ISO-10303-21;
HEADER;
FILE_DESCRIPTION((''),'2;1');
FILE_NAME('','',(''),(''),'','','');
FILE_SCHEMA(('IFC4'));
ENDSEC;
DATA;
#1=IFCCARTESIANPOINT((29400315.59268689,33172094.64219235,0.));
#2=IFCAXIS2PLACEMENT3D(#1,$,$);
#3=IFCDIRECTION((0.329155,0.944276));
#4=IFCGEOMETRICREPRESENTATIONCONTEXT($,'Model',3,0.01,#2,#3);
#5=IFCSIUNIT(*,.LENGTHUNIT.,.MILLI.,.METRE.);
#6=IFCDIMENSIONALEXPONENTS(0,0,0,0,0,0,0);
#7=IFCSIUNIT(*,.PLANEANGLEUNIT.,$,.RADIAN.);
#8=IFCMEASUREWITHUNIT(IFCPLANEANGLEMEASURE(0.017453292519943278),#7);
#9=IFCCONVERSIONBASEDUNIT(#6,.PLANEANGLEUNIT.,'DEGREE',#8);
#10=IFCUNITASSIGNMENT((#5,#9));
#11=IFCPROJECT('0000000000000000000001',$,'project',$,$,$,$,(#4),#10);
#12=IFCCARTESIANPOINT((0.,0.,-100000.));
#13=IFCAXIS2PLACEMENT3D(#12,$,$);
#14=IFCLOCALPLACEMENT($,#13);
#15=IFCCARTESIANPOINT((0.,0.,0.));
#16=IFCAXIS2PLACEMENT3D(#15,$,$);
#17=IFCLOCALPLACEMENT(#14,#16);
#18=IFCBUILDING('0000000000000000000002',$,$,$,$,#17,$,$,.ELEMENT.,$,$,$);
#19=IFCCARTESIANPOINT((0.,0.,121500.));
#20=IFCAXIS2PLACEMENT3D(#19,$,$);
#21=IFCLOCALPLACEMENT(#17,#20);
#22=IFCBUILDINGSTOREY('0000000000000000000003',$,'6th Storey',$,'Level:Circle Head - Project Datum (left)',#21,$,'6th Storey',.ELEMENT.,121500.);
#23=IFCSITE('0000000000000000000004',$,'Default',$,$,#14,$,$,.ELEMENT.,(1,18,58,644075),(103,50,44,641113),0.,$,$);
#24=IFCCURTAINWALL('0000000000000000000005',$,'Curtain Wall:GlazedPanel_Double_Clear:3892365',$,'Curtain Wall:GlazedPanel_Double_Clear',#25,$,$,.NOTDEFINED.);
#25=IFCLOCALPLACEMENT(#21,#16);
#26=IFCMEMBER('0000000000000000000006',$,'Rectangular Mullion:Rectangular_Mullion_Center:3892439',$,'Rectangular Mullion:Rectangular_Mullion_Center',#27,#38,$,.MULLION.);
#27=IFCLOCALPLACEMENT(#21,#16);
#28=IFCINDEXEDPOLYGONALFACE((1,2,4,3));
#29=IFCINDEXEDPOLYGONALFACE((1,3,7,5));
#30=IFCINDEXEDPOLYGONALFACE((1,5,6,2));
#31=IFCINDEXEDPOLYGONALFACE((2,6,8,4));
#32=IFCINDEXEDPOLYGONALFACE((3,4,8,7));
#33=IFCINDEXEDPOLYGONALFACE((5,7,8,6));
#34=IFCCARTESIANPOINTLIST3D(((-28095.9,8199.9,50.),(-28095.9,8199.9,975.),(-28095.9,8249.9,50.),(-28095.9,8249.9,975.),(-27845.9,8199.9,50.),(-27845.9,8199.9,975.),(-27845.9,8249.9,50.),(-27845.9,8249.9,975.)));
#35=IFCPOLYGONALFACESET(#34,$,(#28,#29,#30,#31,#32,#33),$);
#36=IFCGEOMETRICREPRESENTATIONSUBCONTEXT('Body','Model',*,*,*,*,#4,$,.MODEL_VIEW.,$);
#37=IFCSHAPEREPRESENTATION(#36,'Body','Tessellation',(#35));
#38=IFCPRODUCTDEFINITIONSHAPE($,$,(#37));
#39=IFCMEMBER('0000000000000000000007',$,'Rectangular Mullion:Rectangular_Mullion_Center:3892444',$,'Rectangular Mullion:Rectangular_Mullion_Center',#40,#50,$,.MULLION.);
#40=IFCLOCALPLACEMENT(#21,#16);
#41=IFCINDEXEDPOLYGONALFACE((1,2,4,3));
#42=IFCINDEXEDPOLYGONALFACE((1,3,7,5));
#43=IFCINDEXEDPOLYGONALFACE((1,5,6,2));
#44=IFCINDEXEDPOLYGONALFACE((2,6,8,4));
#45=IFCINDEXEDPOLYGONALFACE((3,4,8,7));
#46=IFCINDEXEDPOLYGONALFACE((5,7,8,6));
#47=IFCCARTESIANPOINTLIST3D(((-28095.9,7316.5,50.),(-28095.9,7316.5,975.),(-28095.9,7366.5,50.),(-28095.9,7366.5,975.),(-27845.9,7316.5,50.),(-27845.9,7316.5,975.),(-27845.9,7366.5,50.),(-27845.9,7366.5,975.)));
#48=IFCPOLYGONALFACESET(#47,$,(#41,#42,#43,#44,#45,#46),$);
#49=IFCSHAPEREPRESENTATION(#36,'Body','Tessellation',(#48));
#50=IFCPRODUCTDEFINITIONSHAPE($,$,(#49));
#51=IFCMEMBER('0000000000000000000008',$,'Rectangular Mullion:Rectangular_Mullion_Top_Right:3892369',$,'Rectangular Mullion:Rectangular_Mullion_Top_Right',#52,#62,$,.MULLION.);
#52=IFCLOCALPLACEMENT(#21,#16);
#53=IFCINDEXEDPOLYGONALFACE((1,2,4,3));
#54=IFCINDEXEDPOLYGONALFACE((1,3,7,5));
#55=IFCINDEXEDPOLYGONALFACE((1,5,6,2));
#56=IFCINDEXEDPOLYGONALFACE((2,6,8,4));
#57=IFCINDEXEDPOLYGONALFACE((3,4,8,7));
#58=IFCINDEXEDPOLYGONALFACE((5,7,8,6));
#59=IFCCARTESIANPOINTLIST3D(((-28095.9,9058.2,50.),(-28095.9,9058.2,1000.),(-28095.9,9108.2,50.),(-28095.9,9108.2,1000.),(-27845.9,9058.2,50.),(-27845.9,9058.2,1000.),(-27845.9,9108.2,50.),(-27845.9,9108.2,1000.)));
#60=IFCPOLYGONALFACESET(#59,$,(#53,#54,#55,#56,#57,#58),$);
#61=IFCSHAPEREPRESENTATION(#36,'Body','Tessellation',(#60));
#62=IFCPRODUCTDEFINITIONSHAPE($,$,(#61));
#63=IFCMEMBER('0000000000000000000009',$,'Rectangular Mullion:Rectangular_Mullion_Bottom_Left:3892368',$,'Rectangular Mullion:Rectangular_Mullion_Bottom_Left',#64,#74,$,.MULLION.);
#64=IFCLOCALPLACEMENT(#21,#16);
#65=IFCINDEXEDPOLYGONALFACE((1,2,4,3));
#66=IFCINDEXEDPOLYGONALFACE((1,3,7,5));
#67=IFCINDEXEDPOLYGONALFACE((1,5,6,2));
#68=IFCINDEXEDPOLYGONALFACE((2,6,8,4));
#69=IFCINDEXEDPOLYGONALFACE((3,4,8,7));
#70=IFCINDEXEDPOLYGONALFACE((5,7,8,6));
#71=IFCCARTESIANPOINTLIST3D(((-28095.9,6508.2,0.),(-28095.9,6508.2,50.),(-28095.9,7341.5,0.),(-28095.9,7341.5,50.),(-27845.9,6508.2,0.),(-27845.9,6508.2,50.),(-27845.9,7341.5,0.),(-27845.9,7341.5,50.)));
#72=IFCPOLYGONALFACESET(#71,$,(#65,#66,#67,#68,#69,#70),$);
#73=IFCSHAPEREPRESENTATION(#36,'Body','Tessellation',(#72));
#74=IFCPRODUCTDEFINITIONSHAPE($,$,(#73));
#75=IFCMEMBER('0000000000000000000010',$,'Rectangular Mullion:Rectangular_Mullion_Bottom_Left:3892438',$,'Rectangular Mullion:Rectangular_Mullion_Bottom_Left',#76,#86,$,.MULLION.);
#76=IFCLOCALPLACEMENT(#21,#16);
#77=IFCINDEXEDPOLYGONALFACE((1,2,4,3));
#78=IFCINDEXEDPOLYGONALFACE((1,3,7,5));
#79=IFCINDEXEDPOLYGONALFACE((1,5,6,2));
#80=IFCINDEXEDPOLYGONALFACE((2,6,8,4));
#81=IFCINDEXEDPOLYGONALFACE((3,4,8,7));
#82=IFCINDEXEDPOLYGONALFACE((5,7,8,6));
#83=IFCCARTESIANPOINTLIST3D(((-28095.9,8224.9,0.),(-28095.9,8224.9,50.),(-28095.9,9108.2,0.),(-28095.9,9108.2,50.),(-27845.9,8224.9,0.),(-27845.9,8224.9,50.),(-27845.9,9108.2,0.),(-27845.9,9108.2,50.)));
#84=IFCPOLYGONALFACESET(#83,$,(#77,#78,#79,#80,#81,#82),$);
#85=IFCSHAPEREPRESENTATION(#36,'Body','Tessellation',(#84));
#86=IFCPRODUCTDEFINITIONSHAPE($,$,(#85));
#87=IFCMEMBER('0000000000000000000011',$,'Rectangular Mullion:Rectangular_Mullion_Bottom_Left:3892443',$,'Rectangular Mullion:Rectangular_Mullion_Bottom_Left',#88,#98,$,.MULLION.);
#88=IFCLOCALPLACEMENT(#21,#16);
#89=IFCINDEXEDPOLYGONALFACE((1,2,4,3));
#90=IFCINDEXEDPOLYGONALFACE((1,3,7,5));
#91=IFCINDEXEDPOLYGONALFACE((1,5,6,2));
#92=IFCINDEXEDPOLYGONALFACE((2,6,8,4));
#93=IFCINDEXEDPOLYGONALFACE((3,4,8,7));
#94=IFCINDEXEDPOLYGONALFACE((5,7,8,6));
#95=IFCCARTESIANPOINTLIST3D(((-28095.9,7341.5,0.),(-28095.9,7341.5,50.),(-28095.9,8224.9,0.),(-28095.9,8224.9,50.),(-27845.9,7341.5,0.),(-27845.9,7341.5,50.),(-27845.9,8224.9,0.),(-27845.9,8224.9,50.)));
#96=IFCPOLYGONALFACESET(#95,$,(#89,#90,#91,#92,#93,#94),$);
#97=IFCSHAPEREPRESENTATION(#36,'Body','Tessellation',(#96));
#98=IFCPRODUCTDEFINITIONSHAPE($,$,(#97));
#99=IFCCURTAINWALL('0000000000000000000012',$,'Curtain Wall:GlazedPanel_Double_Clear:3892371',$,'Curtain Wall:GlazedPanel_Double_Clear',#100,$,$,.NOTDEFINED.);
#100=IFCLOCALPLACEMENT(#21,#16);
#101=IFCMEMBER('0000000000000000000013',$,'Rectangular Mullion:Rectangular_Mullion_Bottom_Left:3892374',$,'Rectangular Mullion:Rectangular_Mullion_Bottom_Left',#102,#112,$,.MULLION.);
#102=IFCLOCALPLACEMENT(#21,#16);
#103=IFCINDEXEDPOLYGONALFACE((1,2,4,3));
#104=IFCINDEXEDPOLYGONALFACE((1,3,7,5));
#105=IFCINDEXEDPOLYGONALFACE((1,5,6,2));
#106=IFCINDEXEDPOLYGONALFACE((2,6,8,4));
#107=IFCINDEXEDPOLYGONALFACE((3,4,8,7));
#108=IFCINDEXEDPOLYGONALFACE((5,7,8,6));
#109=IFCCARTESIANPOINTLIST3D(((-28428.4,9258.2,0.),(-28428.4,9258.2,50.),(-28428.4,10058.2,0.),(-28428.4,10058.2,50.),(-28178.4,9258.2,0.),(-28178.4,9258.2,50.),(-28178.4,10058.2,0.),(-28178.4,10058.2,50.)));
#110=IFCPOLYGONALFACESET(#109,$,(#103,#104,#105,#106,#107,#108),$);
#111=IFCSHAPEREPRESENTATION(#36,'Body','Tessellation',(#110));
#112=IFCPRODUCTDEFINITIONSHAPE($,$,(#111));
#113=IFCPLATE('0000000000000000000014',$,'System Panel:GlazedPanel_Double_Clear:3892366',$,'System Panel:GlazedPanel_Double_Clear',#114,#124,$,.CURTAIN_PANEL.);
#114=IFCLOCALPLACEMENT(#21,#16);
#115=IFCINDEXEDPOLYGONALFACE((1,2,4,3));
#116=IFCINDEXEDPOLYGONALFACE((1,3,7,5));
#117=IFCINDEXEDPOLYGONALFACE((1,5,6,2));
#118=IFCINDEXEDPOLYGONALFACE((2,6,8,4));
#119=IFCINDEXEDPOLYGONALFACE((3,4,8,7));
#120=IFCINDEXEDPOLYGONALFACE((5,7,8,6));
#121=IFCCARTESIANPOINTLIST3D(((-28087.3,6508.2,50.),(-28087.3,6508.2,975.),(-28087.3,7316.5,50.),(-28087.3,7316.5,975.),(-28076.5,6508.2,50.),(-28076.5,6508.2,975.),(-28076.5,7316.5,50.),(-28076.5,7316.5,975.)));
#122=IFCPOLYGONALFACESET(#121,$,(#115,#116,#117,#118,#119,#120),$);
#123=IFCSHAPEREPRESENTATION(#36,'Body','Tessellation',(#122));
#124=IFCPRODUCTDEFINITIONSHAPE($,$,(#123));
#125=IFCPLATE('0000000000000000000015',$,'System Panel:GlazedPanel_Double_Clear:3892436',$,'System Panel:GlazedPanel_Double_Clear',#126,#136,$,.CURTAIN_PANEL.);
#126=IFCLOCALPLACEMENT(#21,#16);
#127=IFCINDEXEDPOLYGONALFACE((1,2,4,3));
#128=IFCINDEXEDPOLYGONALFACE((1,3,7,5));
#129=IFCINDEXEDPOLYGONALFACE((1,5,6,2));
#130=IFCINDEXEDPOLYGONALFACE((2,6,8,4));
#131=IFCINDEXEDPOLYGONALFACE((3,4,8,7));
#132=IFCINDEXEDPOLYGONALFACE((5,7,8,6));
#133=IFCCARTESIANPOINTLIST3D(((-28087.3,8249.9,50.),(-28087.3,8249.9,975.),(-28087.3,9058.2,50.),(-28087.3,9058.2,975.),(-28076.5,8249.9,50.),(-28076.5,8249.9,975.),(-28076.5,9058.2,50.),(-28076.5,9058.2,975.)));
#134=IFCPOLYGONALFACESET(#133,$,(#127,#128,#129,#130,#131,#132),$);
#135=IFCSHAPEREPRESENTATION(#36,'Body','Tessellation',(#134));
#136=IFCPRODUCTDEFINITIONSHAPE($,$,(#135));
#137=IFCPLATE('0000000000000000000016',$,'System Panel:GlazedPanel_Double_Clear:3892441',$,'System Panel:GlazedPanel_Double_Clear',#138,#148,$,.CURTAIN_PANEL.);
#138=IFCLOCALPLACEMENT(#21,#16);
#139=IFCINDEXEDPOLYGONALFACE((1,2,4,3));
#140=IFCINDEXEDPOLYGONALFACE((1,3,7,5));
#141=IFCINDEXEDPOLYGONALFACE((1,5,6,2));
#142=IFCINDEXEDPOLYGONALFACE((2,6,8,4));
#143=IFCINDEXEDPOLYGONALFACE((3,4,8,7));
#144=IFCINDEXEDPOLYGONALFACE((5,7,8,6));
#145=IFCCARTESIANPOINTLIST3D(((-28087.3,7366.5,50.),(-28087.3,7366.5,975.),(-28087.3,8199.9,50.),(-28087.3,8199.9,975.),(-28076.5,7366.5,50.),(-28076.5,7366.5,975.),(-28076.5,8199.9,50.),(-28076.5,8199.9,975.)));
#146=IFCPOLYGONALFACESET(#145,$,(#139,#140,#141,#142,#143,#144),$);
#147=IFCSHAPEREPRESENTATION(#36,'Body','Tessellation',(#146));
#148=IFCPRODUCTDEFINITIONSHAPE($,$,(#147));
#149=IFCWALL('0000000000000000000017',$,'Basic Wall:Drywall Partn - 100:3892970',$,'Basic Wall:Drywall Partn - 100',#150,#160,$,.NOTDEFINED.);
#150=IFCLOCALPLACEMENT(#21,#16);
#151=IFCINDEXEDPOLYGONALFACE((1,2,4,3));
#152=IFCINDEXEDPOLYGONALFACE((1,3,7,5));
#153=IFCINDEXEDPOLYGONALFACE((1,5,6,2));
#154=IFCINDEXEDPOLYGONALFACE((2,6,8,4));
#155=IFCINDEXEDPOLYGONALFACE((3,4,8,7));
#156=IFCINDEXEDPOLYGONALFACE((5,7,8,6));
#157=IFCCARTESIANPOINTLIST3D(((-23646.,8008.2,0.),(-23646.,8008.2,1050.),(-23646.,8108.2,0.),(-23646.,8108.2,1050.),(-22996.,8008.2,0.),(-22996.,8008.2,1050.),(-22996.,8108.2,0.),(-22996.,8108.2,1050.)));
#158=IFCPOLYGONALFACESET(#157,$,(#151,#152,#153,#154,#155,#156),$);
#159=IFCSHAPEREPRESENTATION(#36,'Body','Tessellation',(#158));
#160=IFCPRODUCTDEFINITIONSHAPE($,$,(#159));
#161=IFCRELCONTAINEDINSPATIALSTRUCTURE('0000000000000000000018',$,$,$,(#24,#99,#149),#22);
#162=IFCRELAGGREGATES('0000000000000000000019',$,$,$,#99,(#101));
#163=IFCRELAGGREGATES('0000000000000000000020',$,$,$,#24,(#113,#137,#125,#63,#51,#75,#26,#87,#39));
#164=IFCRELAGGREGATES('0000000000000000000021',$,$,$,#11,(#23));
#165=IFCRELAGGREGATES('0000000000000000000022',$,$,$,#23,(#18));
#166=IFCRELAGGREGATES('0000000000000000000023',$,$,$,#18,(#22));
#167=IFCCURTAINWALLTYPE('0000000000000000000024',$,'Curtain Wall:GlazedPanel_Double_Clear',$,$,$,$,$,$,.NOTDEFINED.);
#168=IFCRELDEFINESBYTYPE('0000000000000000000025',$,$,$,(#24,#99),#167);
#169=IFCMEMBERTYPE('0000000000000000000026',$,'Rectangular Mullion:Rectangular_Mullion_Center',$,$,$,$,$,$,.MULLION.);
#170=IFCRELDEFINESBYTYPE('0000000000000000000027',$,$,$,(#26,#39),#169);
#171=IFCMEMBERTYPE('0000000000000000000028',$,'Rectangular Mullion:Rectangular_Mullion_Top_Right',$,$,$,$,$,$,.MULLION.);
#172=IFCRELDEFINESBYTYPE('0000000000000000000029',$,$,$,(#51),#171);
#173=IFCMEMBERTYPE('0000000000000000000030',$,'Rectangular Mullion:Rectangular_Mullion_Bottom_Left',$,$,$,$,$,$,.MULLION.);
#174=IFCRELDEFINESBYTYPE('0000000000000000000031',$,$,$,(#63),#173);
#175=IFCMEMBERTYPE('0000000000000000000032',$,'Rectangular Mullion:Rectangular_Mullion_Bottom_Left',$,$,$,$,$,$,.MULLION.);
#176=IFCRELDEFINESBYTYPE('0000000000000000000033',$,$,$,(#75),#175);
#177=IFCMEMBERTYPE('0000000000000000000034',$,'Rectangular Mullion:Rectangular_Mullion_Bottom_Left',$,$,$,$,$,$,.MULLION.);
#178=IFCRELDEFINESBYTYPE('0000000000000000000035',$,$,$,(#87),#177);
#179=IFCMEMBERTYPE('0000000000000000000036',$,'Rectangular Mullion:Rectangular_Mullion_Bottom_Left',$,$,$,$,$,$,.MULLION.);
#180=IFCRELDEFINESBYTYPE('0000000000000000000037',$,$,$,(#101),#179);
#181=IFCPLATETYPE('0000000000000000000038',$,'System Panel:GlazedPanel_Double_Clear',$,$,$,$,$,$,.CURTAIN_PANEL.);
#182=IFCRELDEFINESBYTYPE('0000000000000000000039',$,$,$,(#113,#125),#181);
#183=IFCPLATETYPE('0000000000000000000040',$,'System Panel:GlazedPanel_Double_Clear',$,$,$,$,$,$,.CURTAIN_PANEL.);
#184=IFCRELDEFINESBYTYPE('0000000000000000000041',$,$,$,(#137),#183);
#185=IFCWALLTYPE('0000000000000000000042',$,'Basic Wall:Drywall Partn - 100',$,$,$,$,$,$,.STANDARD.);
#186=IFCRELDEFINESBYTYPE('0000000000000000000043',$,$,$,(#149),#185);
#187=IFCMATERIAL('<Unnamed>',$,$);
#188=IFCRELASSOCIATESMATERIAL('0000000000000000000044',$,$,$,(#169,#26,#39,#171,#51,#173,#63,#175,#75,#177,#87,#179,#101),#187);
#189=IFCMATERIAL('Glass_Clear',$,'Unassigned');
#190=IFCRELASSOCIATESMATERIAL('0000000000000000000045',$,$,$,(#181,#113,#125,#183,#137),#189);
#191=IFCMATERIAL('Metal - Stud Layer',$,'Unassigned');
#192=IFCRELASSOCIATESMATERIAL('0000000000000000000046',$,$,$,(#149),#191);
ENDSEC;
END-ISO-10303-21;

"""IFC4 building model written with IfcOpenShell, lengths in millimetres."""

from ifc_helpers import new_model, entity, si_unit, converted_unit, direction, frame, origin, place, context, subcontext, project, spatial, indexed_curve, outline, extrude, source, transform, mapped, material, type_object, type_shapes, element, aggregate, save


model = new_model("IFC4")

# Units and contexts
model_context = context("Model", 3, precision=0.01, world=frame((29400315.59268689, 33172094.64219235, 0.0)), true_north=direction((0.329155, 0.944276)))
body_context = subcontext(model_context, "Body", "Model", "MODEL_VIEW")
ifc_project = project(units=[si_unit("LENGTHUNIT", "METRE", prefix="MILLI"), converted_unit("PLANEANGLEUNIT", "DEGREE", entity("IfcPlaneAngleMeasure", 0.017453292519943278), si_unit("PLANEANGLEUNIT", "RADIAN"), dimensions=[0, 0, 0, 0, 0, 0, 0])], contexts=[model_context])

# Site, building, storey
site_placement = place(None, frame((0.0, 0.0, -100000.0)))
site = spatial("IfcSite", under=ifc_project, at=site_placement, Name="Default", CompositionType="ELEMENT", RefLatitude=(1, 18, 58, 644075), RefLongitude=(103, 50, 44, 641113), RefElevation=0.0)
building_placement = place(site_placement, origin())
building = spatial("IfcBuilding", under=site, at=building_placement, CompositionType="ELEMENT")
storey_placement = place(building_placement, frame((0.0, 0.0, 121500.0)))
storey = spatial("IfcBuildingStorey", under=building, at=storey_placement, Name="6th Storey", ObjectType="Level:Circle Head - Project Datum (left)", LongName="6th Storey", CompositionType="ELEMENT", Elevation=121500.0)

# Curtain wall, members
curtain_wall_type = type_object("IfcCurtainWallType", Name="Curtain Wall:GlazedPanel_Double_Clear", PredefinedType="NOTDEFINED")
curtain_wall_1_placement = place(storey_placement, frame((0.0, 0.0, -121500.0)))
curtain_wall_1 = element("IfcCurtainWall", 1, at=curtain_wall_1_placement, inside=storey, type_object=curtain_wall_type, Name="Curtain Wall:GlazedPanel_Double_Clear:3892365", ObjectType="Curtain Wall:GlazedPanel_Double_Clear", PredefinedType="NOTDEFINED")
ifc_material_1 = material(Name="<Unnamed>")
member_type_1 = type_object("IfcMemberType", Name="Rectangular Mullion:Rectangular_Mullion_Center", PredefinedType="MULLION", material=ifc_material_1)
shared_shape_1 = source(origin(), body_context, "Body", "SweptSolid", [
    extrude(outline(indexed_curve([(-25.0, -125.0), (25.0, -125.0), (25.0, 125.0), (-25.0, 125.0), (-25.0, -125.0)], self_intersect=False)), frame((0.0, 0.0, -925.0), z_axis=(0.0, 0.0, 1.0), x_axis=(-1.0, 0.0, 0.0)), (0.0, 0.0, 1.0), 925.0),
])
type_shapes(member_type_1, [shared_shape_1])
member_1_placement = place(curtain_wall_1_placement, frame((-27970.9, 8224.9, 121550.0), z_axis=(0.0, 0.0, -1.0), x_axis=(0.0, 1.0, 0.0)))
member_1 = element("IfcMember", 2, at=member_1_placement, type_object=member_type_1, material=ifc_material_1, Name="Rectangular Mullion:Rectangular_Mullion_Center:3892439", ObjectType="Rectangular Mullion:Rectangular_Mullion_Center", PredefinedType="MULLION", context=body_context, shape_type="MappedRepresentation", body=[
    mapped(shared_shape_1, transform((0.0, 0.0, 0.0), scale=1.0)),
])
member_2_placement = place(curtain_wall_1_placement, frame((-27970.9, 7341.5, 121550.0), z_axis=(0.0, 0.0, -1.0), x_axis=(0.0, 1.0, 0.0)))
member_2 = element("IfcMember", 3, at=member_2_placement, type_object=member_type_1, material=ifc_material_1, Name="Rectangular Mullion:Rectangular_Mullion_Center:3892444", ObjectType="Rectangular Mullion:Rectangular_Mullion_Center", PredefinedType="MULLION", context=body_context, shape_type="MappedRepresentation", body=[
    mapped(shared_shape_1, transform((0.0, 0.0, 0.0), scale=1.0)),
])
member_type_2 = type_object("IfcMemberType", Name="Rectangular Mullion:Rectangular_Mullion_Top_Right", PredefinedType="MULLION", material=ifc_material_1)
shared_shape_2 = source(origin(), body_context, "Body", "SweptSolid", [
    extrude(outline(indexed_curve([(-25.0, -125.0), (25.0, -125.0), (25.0, 125.0), (-25.0, 125.0), (-25.0, -125.0)], self_intersect=False)), frame((-25.0, 0.0, -950.0), z_axis=(0.0, 0.0, 1.0), x_axis=(-1.0, 0.0, 0.0)), (0.0, 0.0, 1.0), 950.0),
])
type_shapes(member_type_2, [shared_shape_2])
member_3_placement = place(curtain_wall_1_placement, frame((-27970.9, 9108.2, 121550.0), z_axis=(0.0, 0.0, -1.0), x_axis=(0.0, 1.0, 0.0)))
member_3 = element("IfcMember", 4, at=member_3_placement, type_object=member_type_2, material=ifc_material_1, Name="Rectangular Mullion:Rectangular_Mullion_Top_Right:3892369", ObjectType="Rectangular Mullion:Rectangular_Mullion_Top_Right", PredefinedType="MULLION", context=body_context, shape_type="MappedRepresentation", body=[
    mapped(shared_shape_2, transform((0.0, 0.0, 0.0), scale=1.0)),
])
member_type_3 = type_object("IfcMemberType", Name="Rectangular Mullion:Rectangular_Mullion_Bottom_Left", PredefinedType="MULLION", material=ifc_material_1)
shared_shape_3 = source(origin(), body_context, "Body", "SweptSolid", [
    extrude(outline(indexed_curve([(-25.0, -125.0), (25.0, -125.0), (25.0, 125.0), (-25.0, 125.0), (-25.0, -125.0)], self_intersect=False)), frame((-25.0, 0.0, -833.3), z_axis=(0.0, 0.0, 1.0), x_axis=(-1.0, 0.0, 0.0)), (0.0, 0.0, 1.0), 833.3),
])
type_shapes(member_type_3, [shared_shape_3])
member_4_placement = place(curtain_wall_1_placement, frame((-27970.9, 6508.2, 121500.0), z_axis=(0.0, -1.0, 0.0), x_axis=(0.0, 0.0, -1.0)))
member_4 = element("IfcMember", 5, at=member_4_placement, type_object=member_type_3, material=ifc_material_1, Name="Rectangular Mullion:Rectangular_Mullion_Bottom_Left:3892368", ObjectType="Rectangular Mullion:Rectangular_Mullion_Bottom_Left", PredefinedType="MULLION", context=body_context, shape_type="MappedRepresentation", body=[
    mapped(shared_shape_3, transform((0.0, 0.0, 0.0), scale=1.0)),
])
member_type_4 = type_object("IfcMemberType", Name="Rectangular Mullion:Rectangular_Mullion_Bottom_Left", PredefinedType="MULLION", material=ifc_material_1)
shared_shape_4 = source(origin(), body_context, "Body", "SweptSolid", [
    extrude(outline(indexed_curve([(-25.0, -125.0), (25.0, -125.0), (25.0, 125.0), (-25.0, 125.0), (-25.0, -125.0)], self_intersect=False)), frame((-25.0, 0.0, -883.3), z_axis=(0.0, 0.0, 1.0), x_axis=(-1.0, 0.0, 0.0)), (0.0, 0.0, 1.0), 883.3),
])
type_shapes(member_type_4, [shared_shape_4])
member_5_placement = place(curtain_wall_1_placement, frame((-27970.9, 8224.9, 121500.0), z_axis=(0.0, -1.0, 0.0), x_axis=(0.0, 0.0, -1.0)))
member_5 = element("IfcMember", 6, at=member_5_placement, type_object=member_type_4, material=ifc_material_1, Name="Rectangular Mullion:Rectangular_Mullion_Bottom_Left:3892438", ObjectType="Rectangular Mullion:Rectangular_Mullion_Bottom_Left", PredefinedType="MULLION", context=body_context, shape_type="MappedRepresentation", body=[
    mapped(shared_shape_4, transform((0.0, 0.0, 0.0), scale=1.0)),
])
member_type_5 = type_object("IfcMemberType", Name="Rectangular Mullion:Rectangular_Mullion_Bottom_Left", PredefinedType="MULLION", material=ifc_material_1)
shared_shape_5 = source(origin(), body_context, "Body", "SweptSolid", [
    extrude(outline(indexed_curve([(-25.0, -125.0), (25.0, -125.0), (25.0, 125.0), (-25.0, 125.0), (-25.0, -125.0)], self_intersect=False)), frame((-25.0, 0.0, -883.3), z_axis=(0.0, 0.0, 1.0), x_axis=(-1.0, 0.0, 0.0)), (0.0, 0.0, 1.0), 883.3),
])
type_shapes(member_type_5, [shared_shape_5])
member_6_placement = place(curtain_wall_1_placement, frame((-27970.9, 7341.5, 121500.0), z_axis=(0.0, -1.0, 0.0), x_axis=(0.0, 0.0, -1.0)))
member_6 = element("IfcMember", 7, at=member_6_placement, type_object=member_type_5, material=ifc_material_1, Name="Rectangular Mullion:Rectangular_Mullion_Bottom_Left:3892443", ObjectType="Rectangular Mullion:Rectangular_Mullion_Bottom_Left", PredefinedType="MULLION", context=body_context, shape_type="MappedRepresentation", body=[
    mapped(shared_shape_5, transform((0.0, 0.0, 0.0), scale=1.0)),
])

# Curtain wall, member
curtain_wall_2_placement = place(storey_placement, frame((0.0, 0.0, -121500.0)))
curtain_wall_2 = element("IfcCurtainWall", 8, at=curtain_wall_2_placement, inside=storey, type_object=curtain_wall_type, Name="Curtain Wall:GlazedPanel_Double_Clear:3892371", ObjectType="Curtain Wall:GlazedPanel_Double_Clear", PredefinedType="NOTDEFINED")
member_type_6 = type_object("IfcMemberType", Name="Rectangular Mullion:Rectangular_Mullion_Bottom_Left", PredefinedType="MULLION", material=ifc_material_1)
shared_shape_6 = source(origin(), body_context, "Body", "SweptSolid", [
    extrude(outline(indexed_curve([(-25.0, -125.0), (25.0, -125.0), (25.0, 125.0), (-25.0, 125.0), (-25.0, -125.0)], self_intersect=False)), frame((-25.0, 0.0, -800.0), z_axis=(0.0, 0.0, 1.0), x_axis=(-1.0, 0.0, 0.0)), (0.0, 0.0, 1.0), 800.0),
])
type_shapes(member_type_6, [shared_shape_6])
member_7_placement = place(curtain_wall_2_placement, frame((-28303.4, 9258.2, 121500.0), z_axis=(0.0, -1.0, 0.0), x_axis=(0.0, 0.0, -1.0)))
member_7 = element("IfcMember", 9, at=member_7_placement, type_object=member_type_6, material=ifc_material_1, Name="Rectangular Mullion:Rectangular_Mullion_Bottom_Left:3892374", ObjectType="Rectangular Mullion:Rectangular_Mullion_Bottom_Left", PredefinedType="MULLION", context=body_context, shape_type="MappedRepresentation", body=[
    mapped(shared_shape_6, transform((0.0, 0.0, 0.0), scale=1.0)),
])
aggregate(curtain_wall_2, [member_7])

# Plates
ifc_material_2 = material(Name="Glass_Clear", Category="Unassigned")
plate_type_1 = type_object("IfcPlateType", Name="System Panel:GlazedPanel_Double_Clear", PredefinedType="CURTAIN_PANEL", material=ifc_material_2)
shared_shape_7 = source(origin(), body_context, "Body", "SweptSolid", [
    extrude(outline(indexed_curve([(-5.4, -404.2), (5.4, -404.2), (5.4, 404.2), (-5.4, 404.2), (-5.4, -404.2)], self_intersect=False)), frame((0.0, 111.0, 0.0), z_axis=(0.0, 0.0, 1.0), x_axis=(0.0, 1.0, 0.0)), (0.0, 0.0, 1.0), 925.0),
])
type_shapes(plate_type_1, [shared_shape_7])
plate_1_placement = place(curtain_wall_1_placement, frame((-27970.9, 6912.4, 121550.0), z_axis=(0.0, 0.0, 1.0), x_axis=(0.0, 1.0, 0.0)))
plate_1 = element("IfcPlate", 10, at=plate_1_placement, type_object=plate_type_1, material=ifc_material_2, Name="System Panel:GlazedPanel_Double_Clear:3892366", ObjectType="System Panel:GlazedPanel_Double_Clear", PredefinedType="CURTAIN_PANEL", context=body_context, shape_type="MappedRepresentation", body=[
    mapped(shared_shape_7, transform((0.0, 0.0, 0.0), scale=1.0)),
])
plate_2_placement = place(curtain_wall_1_placement, frame((-27970.9, 8654.0, 121550.0), z_axis=(0.0, 0.0, 1.0), x_axis=(0.0, 1.0, 0.0)))
plate_2 = element("IfcPlate", 11, at=plate_2_placement, type_object=plate_type_1, material=ifc_material_2, Name="System Panel:GlazedPanel_Double_Clear:3892436", ObjectType="System Panel:GlazedPanel_Double_Clear", PredefinedType="CURTAIN_PANEL", context=body_context, shape_type="MappedRepresentation", body=[
    mapped(shared_shape_7, transform((0.0, 0.0, 0.0), scale=1.0)),
])
plate_type_2 = type_object("IfcPlateType", Name="System Panel:GlazedPanel_Double_Clear", PredefinedType="CURTAIN_PANEL", material=ifc_material_2)
shared_shape_8 = source(origin(), body_context, "Body", "SweptSolid", [
    extrude(outline(indexed_curve([(-5.4, -416.7), (5.4, -416.7), (5.4, 416.7), (-5.4, 416.7), (-5.4, -416.7)], self_intersect=False)), frame((0.0, 111.0, 0.0), z_axis=(0.0, 0.0, 1.0), x_axis=(0.0, 1.0, 0.0)), (0.0, 0.0, 1.0), 925.0),
])
type_shapes(plate_type_2, [shared_shape_8])
plate_3_placement = place(curtain_wall_1_placement, frame((-27970.9, 7783.2, 121550.0), z_axis=(0.0, 0.0, 1.0), x_axis=(0.0, 1.0, 0.0)))
plate_3 = element("IfcPlate", 12, at=plate_3_placement, type_object=plate_type_2, material=ifc_material_2, Name="System Panel:GlazedPanel_Double_Clear:3892441", ObjectType="System Panel:GlazedPanel_Double_Clear", PredefinedType="CURTAIN_PANEL", context=body_context, shape_type="MappedRepresentation", body=[
    mapped(shared_shape_8, transform((0.0, 0.0, 0.0), scale=1.0)),
])
aggregate(curtain_wall_1, [plate_1, plate_3, plate_2, member_4, member_3, member_5, member_1, member_6, member_2])

# Wall
ifc_material_3 = material(Name="Metal - Stud Layer", Category="Unassigned")
wall_type_1 = type_object("IfcWallType", Name="Basic Wall:Drywall Partn - 100", PredefinedType="STANDARD")
wall_1_placement = place(storey_placement, frame((-23646.0, 8058.2, 0.0)))
element("IfcWall", 13, at=wall_1_placement, inside=storey, type_object=wall_type_1, material=ifc_material_3, Name="Basic Wall:Drywall Partn - 100:3892970", ObjectType="Basic Wall:Drywall Partn - 100", PredefinedType="NOTDEFINED", context=body_context, shape_type="SweptSolid", body=[
    extrude(outline(indexed_curve([(650.0, 50.0), (0.0, 50.0), (0.0, -50.0), (650.0, -50.0), (650.0, 50.0)], self_intersect=False)), origin(), (0.0, 0.0, 1.0), 1050.0),
])

save(model, "model.ifc")
